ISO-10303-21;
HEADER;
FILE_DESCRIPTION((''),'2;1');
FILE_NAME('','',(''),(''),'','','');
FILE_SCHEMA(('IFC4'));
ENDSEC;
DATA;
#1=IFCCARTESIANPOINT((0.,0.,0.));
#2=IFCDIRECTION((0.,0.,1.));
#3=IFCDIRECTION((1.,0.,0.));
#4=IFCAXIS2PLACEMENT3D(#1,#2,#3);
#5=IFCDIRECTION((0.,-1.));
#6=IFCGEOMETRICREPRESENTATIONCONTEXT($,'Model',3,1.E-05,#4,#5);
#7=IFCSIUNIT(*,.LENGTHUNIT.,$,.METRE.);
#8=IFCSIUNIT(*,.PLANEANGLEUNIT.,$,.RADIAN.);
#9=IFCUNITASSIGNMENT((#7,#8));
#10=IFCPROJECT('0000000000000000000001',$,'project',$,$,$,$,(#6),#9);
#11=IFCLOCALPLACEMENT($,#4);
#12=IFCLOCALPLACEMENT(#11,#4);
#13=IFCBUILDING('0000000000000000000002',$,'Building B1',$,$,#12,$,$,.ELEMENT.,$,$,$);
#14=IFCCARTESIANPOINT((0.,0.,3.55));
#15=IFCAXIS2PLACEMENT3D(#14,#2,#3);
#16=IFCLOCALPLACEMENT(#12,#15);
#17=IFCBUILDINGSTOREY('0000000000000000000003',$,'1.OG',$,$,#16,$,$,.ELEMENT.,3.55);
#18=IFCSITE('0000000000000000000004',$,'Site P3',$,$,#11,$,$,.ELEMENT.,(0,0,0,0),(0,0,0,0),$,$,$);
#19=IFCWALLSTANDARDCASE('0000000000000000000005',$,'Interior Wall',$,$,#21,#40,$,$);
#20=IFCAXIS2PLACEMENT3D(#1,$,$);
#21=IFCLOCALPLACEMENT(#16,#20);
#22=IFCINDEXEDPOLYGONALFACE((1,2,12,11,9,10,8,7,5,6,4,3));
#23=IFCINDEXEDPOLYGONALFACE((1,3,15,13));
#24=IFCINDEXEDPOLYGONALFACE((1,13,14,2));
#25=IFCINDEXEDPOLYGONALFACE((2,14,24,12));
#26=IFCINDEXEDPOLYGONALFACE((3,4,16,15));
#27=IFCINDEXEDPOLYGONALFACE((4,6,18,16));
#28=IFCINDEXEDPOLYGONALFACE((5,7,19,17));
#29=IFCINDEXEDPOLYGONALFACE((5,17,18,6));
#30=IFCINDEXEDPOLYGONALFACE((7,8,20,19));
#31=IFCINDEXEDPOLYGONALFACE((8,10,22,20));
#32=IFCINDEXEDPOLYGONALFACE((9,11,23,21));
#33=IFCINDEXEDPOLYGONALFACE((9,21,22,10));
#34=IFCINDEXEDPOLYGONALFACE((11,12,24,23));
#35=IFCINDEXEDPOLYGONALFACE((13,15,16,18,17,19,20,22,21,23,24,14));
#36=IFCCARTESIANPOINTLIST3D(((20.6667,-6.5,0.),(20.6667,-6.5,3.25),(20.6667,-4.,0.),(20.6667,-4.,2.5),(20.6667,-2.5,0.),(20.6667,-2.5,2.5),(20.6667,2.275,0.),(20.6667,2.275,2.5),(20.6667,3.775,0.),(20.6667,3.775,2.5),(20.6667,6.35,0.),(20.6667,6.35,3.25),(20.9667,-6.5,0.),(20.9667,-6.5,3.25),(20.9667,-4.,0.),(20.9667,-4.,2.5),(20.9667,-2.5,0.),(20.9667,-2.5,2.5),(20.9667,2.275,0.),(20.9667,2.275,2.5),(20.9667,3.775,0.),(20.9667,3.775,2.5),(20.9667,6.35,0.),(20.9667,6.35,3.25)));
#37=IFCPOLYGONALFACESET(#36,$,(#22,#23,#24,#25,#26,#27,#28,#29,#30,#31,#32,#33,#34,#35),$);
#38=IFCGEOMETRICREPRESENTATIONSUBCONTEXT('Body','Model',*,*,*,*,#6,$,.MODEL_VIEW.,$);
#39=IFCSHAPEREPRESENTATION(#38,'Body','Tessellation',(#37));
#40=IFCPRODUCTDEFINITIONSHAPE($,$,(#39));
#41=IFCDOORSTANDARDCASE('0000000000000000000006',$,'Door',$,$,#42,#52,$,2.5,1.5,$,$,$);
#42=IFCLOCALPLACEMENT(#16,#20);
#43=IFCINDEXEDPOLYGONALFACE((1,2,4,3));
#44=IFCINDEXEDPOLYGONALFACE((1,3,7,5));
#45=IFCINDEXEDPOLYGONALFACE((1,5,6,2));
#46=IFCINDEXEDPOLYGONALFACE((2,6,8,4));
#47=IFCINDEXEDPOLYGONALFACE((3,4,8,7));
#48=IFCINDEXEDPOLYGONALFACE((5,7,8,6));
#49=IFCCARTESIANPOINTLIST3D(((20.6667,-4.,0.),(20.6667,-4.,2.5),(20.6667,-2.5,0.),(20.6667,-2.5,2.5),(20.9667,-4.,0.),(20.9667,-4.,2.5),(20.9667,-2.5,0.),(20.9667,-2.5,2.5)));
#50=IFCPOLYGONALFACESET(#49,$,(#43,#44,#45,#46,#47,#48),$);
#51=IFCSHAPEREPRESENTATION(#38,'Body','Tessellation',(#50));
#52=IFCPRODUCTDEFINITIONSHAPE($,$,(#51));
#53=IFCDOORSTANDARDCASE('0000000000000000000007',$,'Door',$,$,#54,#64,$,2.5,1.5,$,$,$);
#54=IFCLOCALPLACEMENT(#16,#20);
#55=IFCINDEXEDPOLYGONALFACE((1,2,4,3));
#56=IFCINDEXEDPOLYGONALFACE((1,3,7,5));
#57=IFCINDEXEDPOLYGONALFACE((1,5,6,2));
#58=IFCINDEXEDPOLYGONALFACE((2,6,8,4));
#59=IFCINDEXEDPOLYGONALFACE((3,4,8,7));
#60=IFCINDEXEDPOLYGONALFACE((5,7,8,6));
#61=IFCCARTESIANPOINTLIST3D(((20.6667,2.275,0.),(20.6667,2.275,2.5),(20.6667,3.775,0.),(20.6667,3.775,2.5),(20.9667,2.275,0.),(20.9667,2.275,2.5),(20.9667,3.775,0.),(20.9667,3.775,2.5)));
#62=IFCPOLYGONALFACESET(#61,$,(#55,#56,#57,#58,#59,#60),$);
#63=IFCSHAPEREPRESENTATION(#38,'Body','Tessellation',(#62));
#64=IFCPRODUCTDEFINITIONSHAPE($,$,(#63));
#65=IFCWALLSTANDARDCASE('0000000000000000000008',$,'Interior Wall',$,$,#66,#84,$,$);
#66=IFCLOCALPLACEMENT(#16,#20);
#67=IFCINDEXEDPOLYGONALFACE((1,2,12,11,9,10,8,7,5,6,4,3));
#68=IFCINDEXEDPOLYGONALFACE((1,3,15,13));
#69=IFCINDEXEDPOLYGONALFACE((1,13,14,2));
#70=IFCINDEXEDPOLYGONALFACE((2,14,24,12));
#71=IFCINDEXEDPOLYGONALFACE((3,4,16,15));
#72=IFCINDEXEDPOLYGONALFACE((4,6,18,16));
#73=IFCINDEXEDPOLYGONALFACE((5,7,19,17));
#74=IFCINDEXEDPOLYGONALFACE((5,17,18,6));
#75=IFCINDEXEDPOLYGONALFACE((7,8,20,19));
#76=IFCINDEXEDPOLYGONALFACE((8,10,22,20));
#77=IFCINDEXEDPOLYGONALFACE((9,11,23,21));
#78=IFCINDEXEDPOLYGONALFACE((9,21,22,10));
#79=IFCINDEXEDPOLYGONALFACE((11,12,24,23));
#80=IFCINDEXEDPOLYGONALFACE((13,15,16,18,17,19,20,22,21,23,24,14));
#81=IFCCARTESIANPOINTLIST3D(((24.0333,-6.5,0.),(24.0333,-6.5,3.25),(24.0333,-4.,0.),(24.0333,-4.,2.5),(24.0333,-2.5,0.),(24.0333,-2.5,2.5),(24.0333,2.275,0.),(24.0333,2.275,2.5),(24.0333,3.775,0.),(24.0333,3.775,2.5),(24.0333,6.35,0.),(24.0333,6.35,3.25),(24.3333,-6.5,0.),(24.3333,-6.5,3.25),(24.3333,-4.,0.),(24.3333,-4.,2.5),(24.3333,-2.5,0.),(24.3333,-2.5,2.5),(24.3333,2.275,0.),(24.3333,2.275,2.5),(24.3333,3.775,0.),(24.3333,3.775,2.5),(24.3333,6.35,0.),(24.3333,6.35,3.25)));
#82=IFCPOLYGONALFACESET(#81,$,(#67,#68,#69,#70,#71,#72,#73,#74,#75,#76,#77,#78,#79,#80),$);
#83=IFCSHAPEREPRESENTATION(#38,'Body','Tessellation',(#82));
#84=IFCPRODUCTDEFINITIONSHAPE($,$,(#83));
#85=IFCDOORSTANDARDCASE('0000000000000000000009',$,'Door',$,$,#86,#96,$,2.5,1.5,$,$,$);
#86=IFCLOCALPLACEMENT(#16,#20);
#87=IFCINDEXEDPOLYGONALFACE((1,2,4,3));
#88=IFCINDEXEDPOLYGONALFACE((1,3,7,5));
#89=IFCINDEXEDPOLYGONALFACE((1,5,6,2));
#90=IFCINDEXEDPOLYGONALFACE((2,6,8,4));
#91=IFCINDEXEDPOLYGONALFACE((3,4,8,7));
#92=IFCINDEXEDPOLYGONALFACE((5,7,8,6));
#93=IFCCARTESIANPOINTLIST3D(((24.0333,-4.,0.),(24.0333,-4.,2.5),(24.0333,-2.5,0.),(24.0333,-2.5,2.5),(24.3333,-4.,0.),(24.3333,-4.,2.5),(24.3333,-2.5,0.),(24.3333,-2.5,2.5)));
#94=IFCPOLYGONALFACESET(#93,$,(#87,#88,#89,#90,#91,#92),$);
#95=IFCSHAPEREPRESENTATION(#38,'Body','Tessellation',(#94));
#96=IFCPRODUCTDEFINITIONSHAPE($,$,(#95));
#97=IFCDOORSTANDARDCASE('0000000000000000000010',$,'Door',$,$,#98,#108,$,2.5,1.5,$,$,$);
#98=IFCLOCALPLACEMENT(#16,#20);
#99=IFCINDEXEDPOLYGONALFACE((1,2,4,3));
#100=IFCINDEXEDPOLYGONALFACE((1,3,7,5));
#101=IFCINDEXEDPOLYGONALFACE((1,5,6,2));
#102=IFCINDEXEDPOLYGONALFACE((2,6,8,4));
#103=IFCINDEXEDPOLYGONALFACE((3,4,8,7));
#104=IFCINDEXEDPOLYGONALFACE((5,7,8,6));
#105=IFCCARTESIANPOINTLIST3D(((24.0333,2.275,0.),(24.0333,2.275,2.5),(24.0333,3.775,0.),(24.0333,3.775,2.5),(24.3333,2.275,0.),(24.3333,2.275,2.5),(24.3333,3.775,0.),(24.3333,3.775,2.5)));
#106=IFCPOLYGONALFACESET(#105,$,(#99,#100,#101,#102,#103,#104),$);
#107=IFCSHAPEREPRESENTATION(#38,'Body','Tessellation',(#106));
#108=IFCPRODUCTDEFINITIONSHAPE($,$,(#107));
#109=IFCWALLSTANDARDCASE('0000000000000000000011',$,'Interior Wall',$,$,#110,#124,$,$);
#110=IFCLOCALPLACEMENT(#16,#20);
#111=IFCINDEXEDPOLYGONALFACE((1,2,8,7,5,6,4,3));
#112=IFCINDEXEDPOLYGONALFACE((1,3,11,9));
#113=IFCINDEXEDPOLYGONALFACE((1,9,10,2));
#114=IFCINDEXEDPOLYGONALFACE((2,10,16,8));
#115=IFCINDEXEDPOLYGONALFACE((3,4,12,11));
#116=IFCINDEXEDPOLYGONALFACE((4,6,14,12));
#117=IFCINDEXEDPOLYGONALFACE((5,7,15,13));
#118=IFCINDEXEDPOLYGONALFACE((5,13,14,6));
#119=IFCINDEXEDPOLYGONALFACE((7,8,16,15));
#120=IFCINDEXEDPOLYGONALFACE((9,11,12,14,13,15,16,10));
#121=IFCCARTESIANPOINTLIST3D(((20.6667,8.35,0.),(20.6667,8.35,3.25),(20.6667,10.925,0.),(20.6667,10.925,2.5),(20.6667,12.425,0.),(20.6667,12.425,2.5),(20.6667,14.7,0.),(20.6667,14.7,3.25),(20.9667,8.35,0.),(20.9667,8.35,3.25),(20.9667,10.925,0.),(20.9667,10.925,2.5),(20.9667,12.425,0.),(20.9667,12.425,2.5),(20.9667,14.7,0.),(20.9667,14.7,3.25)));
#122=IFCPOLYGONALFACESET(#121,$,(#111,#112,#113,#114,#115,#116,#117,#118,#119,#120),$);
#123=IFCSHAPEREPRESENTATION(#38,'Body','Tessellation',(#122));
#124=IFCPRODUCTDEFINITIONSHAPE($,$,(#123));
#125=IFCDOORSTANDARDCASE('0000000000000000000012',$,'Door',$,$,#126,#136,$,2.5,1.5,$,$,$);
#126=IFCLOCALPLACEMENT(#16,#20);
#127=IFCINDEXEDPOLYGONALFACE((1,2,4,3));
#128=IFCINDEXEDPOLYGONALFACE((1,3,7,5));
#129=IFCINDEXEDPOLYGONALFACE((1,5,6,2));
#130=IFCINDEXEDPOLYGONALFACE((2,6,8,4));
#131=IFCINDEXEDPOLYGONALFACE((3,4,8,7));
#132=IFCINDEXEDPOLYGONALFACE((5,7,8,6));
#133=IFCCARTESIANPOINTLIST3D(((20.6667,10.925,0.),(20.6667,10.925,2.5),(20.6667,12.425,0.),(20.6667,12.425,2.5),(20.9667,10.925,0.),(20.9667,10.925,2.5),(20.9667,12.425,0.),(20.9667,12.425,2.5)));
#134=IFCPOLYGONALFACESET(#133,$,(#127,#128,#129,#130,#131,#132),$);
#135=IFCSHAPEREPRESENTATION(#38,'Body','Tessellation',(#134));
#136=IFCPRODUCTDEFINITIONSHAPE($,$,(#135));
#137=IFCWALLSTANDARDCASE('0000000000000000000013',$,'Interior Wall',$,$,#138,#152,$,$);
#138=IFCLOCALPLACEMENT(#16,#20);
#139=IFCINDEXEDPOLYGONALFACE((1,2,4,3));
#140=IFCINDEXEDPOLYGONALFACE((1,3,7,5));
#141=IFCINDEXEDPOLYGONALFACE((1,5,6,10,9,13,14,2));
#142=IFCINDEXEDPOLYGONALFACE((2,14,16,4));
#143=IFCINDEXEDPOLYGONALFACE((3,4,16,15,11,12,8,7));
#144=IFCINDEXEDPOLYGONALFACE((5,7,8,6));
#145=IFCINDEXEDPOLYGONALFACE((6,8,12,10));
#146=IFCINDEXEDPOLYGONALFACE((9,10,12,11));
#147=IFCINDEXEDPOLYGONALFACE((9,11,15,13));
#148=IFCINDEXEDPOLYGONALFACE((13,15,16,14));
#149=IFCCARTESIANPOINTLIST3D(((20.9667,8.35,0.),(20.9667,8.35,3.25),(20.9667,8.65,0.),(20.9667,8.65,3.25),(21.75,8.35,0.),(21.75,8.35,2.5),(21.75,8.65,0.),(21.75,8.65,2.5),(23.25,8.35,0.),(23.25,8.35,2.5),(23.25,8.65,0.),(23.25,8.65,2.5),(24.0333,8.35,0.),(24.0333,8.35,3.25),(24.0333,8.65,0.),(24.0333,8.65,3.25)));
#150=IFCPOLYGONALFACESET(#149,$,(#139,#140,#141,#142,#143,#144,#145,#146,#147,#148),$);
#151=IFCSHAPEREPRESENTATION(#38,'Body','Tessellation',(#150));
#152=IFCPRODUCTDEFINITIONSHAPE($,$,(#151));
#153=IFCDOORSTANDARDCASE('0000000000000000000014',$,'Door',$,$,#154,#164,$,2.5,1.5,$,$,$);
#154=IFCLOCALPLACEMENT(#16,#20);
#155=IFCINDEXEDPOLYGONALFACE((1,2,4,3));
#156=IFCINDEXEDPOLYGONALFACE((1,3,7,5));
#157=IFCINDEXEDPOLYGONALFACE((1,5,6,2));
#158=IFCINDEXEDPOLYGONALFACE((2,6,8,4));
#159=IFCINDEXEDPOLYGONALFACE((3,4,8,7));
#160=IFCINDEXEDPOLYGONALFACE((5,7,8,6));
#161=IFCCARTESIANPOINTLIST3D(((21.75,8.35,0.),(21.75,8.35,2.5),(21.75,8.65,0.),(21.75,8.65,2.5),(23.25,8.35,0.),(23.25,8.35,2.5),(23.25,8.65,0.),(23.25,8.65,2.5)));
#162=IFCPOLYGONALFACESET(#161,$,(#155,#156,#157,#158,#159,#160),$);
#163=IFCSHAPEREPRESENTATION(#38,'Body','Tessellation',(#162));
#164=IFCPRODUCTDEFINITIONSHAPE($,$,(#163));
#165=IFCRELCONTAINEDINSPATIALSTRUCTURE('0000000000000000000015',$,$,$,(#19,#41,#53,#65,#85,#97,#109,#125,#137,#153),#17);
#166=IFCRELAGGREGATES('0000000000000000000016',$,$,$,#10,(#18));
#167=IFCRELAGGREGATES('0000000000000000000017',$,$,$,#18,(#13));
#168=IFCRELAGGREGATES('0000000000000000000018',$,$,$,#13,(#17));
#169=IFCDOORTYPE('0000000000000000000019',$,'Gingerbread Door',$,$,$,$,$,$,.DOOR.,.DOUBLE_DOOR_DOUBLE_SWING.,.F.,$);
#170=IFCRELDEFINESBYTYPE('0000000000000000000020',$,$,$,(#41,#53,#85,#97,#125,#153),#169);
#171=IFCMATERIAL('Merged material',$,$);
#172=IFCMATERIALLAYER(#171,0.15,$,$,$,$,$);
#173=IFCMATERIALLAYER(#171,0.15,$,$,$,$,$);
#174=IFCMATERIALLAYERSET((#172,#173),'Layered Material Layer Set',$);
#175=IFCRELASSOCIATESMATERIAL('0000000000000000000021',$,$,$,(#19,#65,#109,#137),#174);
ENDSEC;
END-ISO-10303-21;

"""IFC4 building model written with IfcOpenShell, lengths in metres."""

from ifc_helpers import new_model, si_unit, direction, frame, origin_with_axes, place, context, subcontext, project, spatial, polyline, outline, extrude, source, transform, mapped, material, layer, layer_set, layer_usage, type_object, element, fill, save


model = new_model("IFC4")

# Units and contexts
model_context = context("Model", 3, precision=1e-05, world=origin_with_axes(), true_north=direction((0.0, -1.0)))
body_context = subcontext(model_context, "Body", "Model", "MODEL_VIEW")
ifc_project = project(units=[si_unit("LENGTHUNIT", "METRE"), si_unit("PLANEANGLEUNIT", "RADIAN")], contexts=[model_context])

# Site, building, storey
site_placement = place(None, origin_with_axes())
site = spatial("IfcSite", under=ifc_project, at=site_placement, Name="Site P3", CompositionType="ELEMENT", RefLatitude=(0, 0, 0, 0), RefLongitude=(0, 0, 0, 0))
building_placement = place(site_placement, origin_with_axes())
building = spatial("IfcBuilding", under=site, at=building_placement, Name="Building B1", CompositionType="ELEMENT")
storey_placement = place(building_placement, frame((0.0, 0.0, 3.55), z_axis=(0.0, 0.0, 1.0), x_axis=(1.0, 0.0, 0.0)))
storey = spatial("IfcBuildingStorey", under=building, at=storey_placement, Name="1.OG", CompositionType="ELEMENT", Elevation=3.55)

# Walls, openings, doors
ifc_material = material(Name="Merged material")
ifc_layer_1 = layer(ifc_material, 0.15)
ifc_layer_2 = layer(ifc_material, 0.15)
ifc_layer_set = layer_set([ifc_layer_1, ifc_layer_2], Name="Layered Material Layer Set")
ifc_layer_usage = layer_usage(ifc_layer_set, "AXIS2", "POSITIVE", -0.15)
wall_1_placement = place(storey_placement, frame((20.8167, 6.35, 0.0), z_axis=(0.0, 0.0, 1.0), x_axis=(0.0, -1.0, 0.0)))
wall_1 = element("IfcWallStandardCase", 1, at=wall_1_placement, inside=storey, material=ifc_layer_usage, Name="Interior Wall", context=body_context, shape_type="SweptSolid", body=[
    extrude(outline(polyline([(0.0, 0.15), (12.85, 0.15), (12.85, -0.15), (0.0, -0.15), (0.0, 0.15)])), origin_with_axes(), (0.0, 0.0, 1.0), 3.25),
])
opening_1_placement = place(wall_1_placement, frame((8.85, 0.0, 0.0), z_axis=(0.0, 0.0, 1.0), x_axis=(1.0, 0.0, 0.0)))
opening_1 = element("IfcOpeningStandardCase", 2, at=opening_1_placement, cuts=wall_1, context=body_context, shape_type="SweptSolid", body=[
    extrude(outline(polyline([(0.0, 0.0), (0.0, 1.5), (2.5, 1.5), (2.5, 0.0), (0.0, 0.0)])), frame((0.0, -0.15, 0.0), z_axis=(0.0, 1.0, 0.0), x_axis=(0.0, 0.0, 1.0)), (0.0, 0.0, 1.0), 0.3),
])
opening_2_placement = place(wall_1_placement, frame((2.575, 0.0, 0.0), z_axis=(0.0, 0.0, 1.0), x_axis=(1.0, 0.0, 0.0)))
opening_2 = element("IfcOpeningStandardCase", 3, at=opening_2_placement, cuts=wall_1, context=body_context, shape_type="SweptSolid", body=[
    extrude(outline(polyline([(0.0, 0.0), (0.0, 1.5), (2.5, 1.5), (2.5, 0.0), (0.0, 0.0)])), frame((0.0, -0.15, 0.0), z_axis=(0.0, 1.0, 0.0), x_axis=(0.0, 0.0, 1.0)), (0.0, 0.0, 1.0), 0.3),
])
door_type = type_object("IfcDoorType", Name="Gingerbread Door", OperationType="DOUBLE_DOOR_DOUBLE_SWING", ParameterTakesPrecedence=False, PredefinedType="DOOR")
shared_shape = source(origin_with_axes(), body_context, "Body", "SweptSolid", [
    extrude(outline(polyline([(0.0, 0.0), (0.0, 1.5), (2.5, 1.5), (2.5, 0.0), (0.0, 0.0)])), frame((0.0, -0.15, 0.0), z_axis=(0.0, 1.0, 0.0), x_axis=(0.0, 0.0, 1.0)), (0.0, 0.0, 1.0), 0.3),
])
door_1_placement = place(opening_1_placement, origin_with_axes())
door_1 = element("IfcDoorStandardCase", 4, at=door_1_placement, inside=storey, type_object=door_type, Name="Door", OverallHeight=2.5, OverallWidth=1.5, context=body_context, shape_type="MappedRepresentation", body=[
    mapped(shared_shape, transform((0.0, 0.0, 0.0))),
])
fill(opening_1, door_1)
door_2_placement = place(opening_2_placement, origin_with_axes())
door_2 = element("IfcDoorStandardCase", 5, at=door_2_placement, inside=storey, type_object=door_type, Name="Door", OverallHeight=2.5, OverallWidth=1.5, context=body_context, shape_type="MappedRepresentation", body=[
    mapped(shared_shape, transform((0.0, 0.0, 0.0))),
])
fill(opening_2, door_2)
wall_2_placement = place(storey_placement, frame((24.1833, 6.35, 0.0), z_axis=(0.0, 0.0, 1.0), x_axis=(0.0, -1.0, 0.0)))
wall_2 = element("IfcWallStandardCase", 6, at=wall_2_placement, inside=storey, material=ifc_layer_usage, Name="Interior Wall", context=body_context, shape_type="SweptSolid", body=[
    extrude(outline(polyline([(0.0, 0.15), (12.85, 0.15), (12.85, -0.15), (0.0, -0.15), (0.0, 0.15)])), origin_with_axes(), (0.0, 0.0, 1.0), 3.25),
])
opening_3_placement = place(wall_2_placement, frame((8.85, 0.0, 0.0), z_axis=(0.0, 0.0, 1.0), x_axis=(1.0, 0.0, 0.0)))
opening_3 = element("IfcOpeningStandardCase", 7, at=opening_3_placement, cuts=wall_2, context=body_context, shape_type="SweptSolid", body=[
    extrude(outline(polyline([(0.0, 0.0), (0.0, 1.5), (2.5, 1.5), (2.5, 0.0), (0.0, 0.0)])), frame((0.0, -0.15, 0.0), z_axis=(0.0, 1.0, 0.0), x_axis=(0.0, 0.0, 1.0)), (0.0, 0.0, 1.0), 0.3),
])
opening_4_placement = place(wall_2_placement, frame((2.575, 0.0, 0.0), z_axis=(0.0, 0.0, 1.0), x_axis=(1.0, 0.0, 0.0)))
opening_4 = element("IfcOpeningStandardCase", 8, at=opening_4_placement, cuts=wall_2, context=body_context, shape_type="SweptSolid", body=[
    extrude(outline(polyline([(0.0, 0.0), (0.0, 1.5), (2.5, 1.5), (2.5, 0.0), (0.0, 0.0)])), frame((0.0, -0.15, 0.0), z_axis=(0.0, 1.0, 0.0), x_axis=(0.0, 0.0, 1.0)), (0.0, 0.0, 1.0), 0.3),
])
door_3_placement = place(opening_3_placement, origin_with_axes())
door_3 = element("IfcDoorStandardCase", 9, at=door_3_placement, inside=storey, type_object=door_type, Name="Door", OverallHeight=2.5, OverallWidth=1.5, context=body_context, shape_type="MappedRepresentation", body=[
    mapped(shared_shape, transform((0.0, 0.0, 0.0))),
])
fill(opening_3, door_3)
door_4_placement = place(opening_4_placement, origin_with_axes())
door_4 = element("IfcDoorStandardCase", 10, at=door_4_placement, inside=storey, type_object=door_type, Name="Door", OverallHeight=2.5, OverallWidth=1.5, context=body_context, shape_type="MappedRepresentation", body=[
    mapped(shared_shape, transform((0.0, 0.0, 0.0))),
])
fill(opening_4, door_4)

# Walls, openings, doors
wall_3_placement = place(storey_placement, frame((20.8167, 14.7, 0.0), z_axis=(0.0, 0.0, 1.0), x_axis=(0.0, -1.0, 0.0)))
wall_3 = element("IfcWallStandardCase", 11, at=wall_3_placement, inside=storey, material=ifc_layer_usage, Name="Interior Wall", context=body_context, shape_type="SweptSolid", body=[
    extrude(outline(polyline([(0.0, 0.15), (6.35, 0.15), (6.35, -0.15), (0.0, -0.15), (0.0, 0.15)])), origin_with_axes(), (0.0, 0.0, 1.0), 3.25),
])
opening_5_placement = place(wall_3_placement, frame((2.275, 0.0, 0.0), z_axis=(0.0, 0.0, 1.0), x_axis=(1.0, 0.0, 0.0)))
opening_5 = element("IfcOpeningStandardCase", 12, at=opening_5_placement, cuts=wall_3, context=body_context, shape_type="SweptSolid", body=[
    extrude(outline(polyline([(0.0, 0.0), (0.0, 1.5), (2.5, 1.5), (2.5, 0.0), (0.0, 0.0)])), frame((0.0, -0.15, 0.0), z_axis=(0.0, 1.0, 0.0), x_axis=(0.0, 0.0, 1.0)), (0.0, 0.0, 1.0), 0.3),
])
door_5_placement = place(opening_5_placement, origin_with_axes())
door_5 = element("IfcDoorStandardCase", 13, at=door_5_placement, inside=storey, type_object=door_type, Name="Door", OverallHeight=2.5, OverallWidth=1.5, context=body_context, shape_type="MappedRepresentation", body=[
    mapped(shared_shape, transform((0.0, 0.0, 0.0))),
])
fill(opening_5, door_5)
wall_4_placement = place(storey_placement, frame((20.9667, 8.5, 0.0), z_axis=(0.0, 0.0, 1.0), x_axis=(1.0, 0.0, 0.0)))
wall_4 = element("IfcWallStandardCase", 14, at=wall_4_placement, inside=storey, material=ifc_layer_usage, Name="Interior Wall", context=body_context, shape_type="SweptSolid", body=[
    extrude(outline(polyline([(0.0, 0.15), (3.0667, 0.15), (3.0667, -0.15), (0.0, -0.15), (0.0, 0.15)])), origin_with_axes(), (0.0, 0.0, 1.0), 3.25),
])
opening_6_placement = place(wall_4_placement, frame((0.7833, 0.0, 0.0), z_axis=(0.0, 0.0, 1.0), x_axis=(1.0, 0.0, 0.0)))
opening_6 = element("IfcOpeningStandardCase", 15, at=opening_6_placement, cuts=wall_4, context=body_context, shape_type="SweptSolid", body=[
    extrude(outline(polyline([(0.0, 0.0), (0.0, 1.5), (2.5, 1.5), (2.5, 0.0), (0.0, 0.0)])), frame((0.0, -0.15, 0.0), z_axis=(0.0, 1.0, 0.0), x_axis=(0.0, 0.0, 1.0)), (0.0, 0.0, 1.0), 0.3),
])
door_6_placement = place(opening_6_placement, origin_with_axes())
door_6 = element("IfcDoorStandardCase", 16, at=door_6_placement, inside=storey, type_object=door_type, Name="Door", OverallHeight=2.5, OverallWidth=1.5, context=body_context, shape_type="MappedRepresentation", body=[
    mapped(shared_shape, transform((0.0, 0.0, 0.0))),
])
fill(opening_6, door_6)

save(model, "model.ifc")
